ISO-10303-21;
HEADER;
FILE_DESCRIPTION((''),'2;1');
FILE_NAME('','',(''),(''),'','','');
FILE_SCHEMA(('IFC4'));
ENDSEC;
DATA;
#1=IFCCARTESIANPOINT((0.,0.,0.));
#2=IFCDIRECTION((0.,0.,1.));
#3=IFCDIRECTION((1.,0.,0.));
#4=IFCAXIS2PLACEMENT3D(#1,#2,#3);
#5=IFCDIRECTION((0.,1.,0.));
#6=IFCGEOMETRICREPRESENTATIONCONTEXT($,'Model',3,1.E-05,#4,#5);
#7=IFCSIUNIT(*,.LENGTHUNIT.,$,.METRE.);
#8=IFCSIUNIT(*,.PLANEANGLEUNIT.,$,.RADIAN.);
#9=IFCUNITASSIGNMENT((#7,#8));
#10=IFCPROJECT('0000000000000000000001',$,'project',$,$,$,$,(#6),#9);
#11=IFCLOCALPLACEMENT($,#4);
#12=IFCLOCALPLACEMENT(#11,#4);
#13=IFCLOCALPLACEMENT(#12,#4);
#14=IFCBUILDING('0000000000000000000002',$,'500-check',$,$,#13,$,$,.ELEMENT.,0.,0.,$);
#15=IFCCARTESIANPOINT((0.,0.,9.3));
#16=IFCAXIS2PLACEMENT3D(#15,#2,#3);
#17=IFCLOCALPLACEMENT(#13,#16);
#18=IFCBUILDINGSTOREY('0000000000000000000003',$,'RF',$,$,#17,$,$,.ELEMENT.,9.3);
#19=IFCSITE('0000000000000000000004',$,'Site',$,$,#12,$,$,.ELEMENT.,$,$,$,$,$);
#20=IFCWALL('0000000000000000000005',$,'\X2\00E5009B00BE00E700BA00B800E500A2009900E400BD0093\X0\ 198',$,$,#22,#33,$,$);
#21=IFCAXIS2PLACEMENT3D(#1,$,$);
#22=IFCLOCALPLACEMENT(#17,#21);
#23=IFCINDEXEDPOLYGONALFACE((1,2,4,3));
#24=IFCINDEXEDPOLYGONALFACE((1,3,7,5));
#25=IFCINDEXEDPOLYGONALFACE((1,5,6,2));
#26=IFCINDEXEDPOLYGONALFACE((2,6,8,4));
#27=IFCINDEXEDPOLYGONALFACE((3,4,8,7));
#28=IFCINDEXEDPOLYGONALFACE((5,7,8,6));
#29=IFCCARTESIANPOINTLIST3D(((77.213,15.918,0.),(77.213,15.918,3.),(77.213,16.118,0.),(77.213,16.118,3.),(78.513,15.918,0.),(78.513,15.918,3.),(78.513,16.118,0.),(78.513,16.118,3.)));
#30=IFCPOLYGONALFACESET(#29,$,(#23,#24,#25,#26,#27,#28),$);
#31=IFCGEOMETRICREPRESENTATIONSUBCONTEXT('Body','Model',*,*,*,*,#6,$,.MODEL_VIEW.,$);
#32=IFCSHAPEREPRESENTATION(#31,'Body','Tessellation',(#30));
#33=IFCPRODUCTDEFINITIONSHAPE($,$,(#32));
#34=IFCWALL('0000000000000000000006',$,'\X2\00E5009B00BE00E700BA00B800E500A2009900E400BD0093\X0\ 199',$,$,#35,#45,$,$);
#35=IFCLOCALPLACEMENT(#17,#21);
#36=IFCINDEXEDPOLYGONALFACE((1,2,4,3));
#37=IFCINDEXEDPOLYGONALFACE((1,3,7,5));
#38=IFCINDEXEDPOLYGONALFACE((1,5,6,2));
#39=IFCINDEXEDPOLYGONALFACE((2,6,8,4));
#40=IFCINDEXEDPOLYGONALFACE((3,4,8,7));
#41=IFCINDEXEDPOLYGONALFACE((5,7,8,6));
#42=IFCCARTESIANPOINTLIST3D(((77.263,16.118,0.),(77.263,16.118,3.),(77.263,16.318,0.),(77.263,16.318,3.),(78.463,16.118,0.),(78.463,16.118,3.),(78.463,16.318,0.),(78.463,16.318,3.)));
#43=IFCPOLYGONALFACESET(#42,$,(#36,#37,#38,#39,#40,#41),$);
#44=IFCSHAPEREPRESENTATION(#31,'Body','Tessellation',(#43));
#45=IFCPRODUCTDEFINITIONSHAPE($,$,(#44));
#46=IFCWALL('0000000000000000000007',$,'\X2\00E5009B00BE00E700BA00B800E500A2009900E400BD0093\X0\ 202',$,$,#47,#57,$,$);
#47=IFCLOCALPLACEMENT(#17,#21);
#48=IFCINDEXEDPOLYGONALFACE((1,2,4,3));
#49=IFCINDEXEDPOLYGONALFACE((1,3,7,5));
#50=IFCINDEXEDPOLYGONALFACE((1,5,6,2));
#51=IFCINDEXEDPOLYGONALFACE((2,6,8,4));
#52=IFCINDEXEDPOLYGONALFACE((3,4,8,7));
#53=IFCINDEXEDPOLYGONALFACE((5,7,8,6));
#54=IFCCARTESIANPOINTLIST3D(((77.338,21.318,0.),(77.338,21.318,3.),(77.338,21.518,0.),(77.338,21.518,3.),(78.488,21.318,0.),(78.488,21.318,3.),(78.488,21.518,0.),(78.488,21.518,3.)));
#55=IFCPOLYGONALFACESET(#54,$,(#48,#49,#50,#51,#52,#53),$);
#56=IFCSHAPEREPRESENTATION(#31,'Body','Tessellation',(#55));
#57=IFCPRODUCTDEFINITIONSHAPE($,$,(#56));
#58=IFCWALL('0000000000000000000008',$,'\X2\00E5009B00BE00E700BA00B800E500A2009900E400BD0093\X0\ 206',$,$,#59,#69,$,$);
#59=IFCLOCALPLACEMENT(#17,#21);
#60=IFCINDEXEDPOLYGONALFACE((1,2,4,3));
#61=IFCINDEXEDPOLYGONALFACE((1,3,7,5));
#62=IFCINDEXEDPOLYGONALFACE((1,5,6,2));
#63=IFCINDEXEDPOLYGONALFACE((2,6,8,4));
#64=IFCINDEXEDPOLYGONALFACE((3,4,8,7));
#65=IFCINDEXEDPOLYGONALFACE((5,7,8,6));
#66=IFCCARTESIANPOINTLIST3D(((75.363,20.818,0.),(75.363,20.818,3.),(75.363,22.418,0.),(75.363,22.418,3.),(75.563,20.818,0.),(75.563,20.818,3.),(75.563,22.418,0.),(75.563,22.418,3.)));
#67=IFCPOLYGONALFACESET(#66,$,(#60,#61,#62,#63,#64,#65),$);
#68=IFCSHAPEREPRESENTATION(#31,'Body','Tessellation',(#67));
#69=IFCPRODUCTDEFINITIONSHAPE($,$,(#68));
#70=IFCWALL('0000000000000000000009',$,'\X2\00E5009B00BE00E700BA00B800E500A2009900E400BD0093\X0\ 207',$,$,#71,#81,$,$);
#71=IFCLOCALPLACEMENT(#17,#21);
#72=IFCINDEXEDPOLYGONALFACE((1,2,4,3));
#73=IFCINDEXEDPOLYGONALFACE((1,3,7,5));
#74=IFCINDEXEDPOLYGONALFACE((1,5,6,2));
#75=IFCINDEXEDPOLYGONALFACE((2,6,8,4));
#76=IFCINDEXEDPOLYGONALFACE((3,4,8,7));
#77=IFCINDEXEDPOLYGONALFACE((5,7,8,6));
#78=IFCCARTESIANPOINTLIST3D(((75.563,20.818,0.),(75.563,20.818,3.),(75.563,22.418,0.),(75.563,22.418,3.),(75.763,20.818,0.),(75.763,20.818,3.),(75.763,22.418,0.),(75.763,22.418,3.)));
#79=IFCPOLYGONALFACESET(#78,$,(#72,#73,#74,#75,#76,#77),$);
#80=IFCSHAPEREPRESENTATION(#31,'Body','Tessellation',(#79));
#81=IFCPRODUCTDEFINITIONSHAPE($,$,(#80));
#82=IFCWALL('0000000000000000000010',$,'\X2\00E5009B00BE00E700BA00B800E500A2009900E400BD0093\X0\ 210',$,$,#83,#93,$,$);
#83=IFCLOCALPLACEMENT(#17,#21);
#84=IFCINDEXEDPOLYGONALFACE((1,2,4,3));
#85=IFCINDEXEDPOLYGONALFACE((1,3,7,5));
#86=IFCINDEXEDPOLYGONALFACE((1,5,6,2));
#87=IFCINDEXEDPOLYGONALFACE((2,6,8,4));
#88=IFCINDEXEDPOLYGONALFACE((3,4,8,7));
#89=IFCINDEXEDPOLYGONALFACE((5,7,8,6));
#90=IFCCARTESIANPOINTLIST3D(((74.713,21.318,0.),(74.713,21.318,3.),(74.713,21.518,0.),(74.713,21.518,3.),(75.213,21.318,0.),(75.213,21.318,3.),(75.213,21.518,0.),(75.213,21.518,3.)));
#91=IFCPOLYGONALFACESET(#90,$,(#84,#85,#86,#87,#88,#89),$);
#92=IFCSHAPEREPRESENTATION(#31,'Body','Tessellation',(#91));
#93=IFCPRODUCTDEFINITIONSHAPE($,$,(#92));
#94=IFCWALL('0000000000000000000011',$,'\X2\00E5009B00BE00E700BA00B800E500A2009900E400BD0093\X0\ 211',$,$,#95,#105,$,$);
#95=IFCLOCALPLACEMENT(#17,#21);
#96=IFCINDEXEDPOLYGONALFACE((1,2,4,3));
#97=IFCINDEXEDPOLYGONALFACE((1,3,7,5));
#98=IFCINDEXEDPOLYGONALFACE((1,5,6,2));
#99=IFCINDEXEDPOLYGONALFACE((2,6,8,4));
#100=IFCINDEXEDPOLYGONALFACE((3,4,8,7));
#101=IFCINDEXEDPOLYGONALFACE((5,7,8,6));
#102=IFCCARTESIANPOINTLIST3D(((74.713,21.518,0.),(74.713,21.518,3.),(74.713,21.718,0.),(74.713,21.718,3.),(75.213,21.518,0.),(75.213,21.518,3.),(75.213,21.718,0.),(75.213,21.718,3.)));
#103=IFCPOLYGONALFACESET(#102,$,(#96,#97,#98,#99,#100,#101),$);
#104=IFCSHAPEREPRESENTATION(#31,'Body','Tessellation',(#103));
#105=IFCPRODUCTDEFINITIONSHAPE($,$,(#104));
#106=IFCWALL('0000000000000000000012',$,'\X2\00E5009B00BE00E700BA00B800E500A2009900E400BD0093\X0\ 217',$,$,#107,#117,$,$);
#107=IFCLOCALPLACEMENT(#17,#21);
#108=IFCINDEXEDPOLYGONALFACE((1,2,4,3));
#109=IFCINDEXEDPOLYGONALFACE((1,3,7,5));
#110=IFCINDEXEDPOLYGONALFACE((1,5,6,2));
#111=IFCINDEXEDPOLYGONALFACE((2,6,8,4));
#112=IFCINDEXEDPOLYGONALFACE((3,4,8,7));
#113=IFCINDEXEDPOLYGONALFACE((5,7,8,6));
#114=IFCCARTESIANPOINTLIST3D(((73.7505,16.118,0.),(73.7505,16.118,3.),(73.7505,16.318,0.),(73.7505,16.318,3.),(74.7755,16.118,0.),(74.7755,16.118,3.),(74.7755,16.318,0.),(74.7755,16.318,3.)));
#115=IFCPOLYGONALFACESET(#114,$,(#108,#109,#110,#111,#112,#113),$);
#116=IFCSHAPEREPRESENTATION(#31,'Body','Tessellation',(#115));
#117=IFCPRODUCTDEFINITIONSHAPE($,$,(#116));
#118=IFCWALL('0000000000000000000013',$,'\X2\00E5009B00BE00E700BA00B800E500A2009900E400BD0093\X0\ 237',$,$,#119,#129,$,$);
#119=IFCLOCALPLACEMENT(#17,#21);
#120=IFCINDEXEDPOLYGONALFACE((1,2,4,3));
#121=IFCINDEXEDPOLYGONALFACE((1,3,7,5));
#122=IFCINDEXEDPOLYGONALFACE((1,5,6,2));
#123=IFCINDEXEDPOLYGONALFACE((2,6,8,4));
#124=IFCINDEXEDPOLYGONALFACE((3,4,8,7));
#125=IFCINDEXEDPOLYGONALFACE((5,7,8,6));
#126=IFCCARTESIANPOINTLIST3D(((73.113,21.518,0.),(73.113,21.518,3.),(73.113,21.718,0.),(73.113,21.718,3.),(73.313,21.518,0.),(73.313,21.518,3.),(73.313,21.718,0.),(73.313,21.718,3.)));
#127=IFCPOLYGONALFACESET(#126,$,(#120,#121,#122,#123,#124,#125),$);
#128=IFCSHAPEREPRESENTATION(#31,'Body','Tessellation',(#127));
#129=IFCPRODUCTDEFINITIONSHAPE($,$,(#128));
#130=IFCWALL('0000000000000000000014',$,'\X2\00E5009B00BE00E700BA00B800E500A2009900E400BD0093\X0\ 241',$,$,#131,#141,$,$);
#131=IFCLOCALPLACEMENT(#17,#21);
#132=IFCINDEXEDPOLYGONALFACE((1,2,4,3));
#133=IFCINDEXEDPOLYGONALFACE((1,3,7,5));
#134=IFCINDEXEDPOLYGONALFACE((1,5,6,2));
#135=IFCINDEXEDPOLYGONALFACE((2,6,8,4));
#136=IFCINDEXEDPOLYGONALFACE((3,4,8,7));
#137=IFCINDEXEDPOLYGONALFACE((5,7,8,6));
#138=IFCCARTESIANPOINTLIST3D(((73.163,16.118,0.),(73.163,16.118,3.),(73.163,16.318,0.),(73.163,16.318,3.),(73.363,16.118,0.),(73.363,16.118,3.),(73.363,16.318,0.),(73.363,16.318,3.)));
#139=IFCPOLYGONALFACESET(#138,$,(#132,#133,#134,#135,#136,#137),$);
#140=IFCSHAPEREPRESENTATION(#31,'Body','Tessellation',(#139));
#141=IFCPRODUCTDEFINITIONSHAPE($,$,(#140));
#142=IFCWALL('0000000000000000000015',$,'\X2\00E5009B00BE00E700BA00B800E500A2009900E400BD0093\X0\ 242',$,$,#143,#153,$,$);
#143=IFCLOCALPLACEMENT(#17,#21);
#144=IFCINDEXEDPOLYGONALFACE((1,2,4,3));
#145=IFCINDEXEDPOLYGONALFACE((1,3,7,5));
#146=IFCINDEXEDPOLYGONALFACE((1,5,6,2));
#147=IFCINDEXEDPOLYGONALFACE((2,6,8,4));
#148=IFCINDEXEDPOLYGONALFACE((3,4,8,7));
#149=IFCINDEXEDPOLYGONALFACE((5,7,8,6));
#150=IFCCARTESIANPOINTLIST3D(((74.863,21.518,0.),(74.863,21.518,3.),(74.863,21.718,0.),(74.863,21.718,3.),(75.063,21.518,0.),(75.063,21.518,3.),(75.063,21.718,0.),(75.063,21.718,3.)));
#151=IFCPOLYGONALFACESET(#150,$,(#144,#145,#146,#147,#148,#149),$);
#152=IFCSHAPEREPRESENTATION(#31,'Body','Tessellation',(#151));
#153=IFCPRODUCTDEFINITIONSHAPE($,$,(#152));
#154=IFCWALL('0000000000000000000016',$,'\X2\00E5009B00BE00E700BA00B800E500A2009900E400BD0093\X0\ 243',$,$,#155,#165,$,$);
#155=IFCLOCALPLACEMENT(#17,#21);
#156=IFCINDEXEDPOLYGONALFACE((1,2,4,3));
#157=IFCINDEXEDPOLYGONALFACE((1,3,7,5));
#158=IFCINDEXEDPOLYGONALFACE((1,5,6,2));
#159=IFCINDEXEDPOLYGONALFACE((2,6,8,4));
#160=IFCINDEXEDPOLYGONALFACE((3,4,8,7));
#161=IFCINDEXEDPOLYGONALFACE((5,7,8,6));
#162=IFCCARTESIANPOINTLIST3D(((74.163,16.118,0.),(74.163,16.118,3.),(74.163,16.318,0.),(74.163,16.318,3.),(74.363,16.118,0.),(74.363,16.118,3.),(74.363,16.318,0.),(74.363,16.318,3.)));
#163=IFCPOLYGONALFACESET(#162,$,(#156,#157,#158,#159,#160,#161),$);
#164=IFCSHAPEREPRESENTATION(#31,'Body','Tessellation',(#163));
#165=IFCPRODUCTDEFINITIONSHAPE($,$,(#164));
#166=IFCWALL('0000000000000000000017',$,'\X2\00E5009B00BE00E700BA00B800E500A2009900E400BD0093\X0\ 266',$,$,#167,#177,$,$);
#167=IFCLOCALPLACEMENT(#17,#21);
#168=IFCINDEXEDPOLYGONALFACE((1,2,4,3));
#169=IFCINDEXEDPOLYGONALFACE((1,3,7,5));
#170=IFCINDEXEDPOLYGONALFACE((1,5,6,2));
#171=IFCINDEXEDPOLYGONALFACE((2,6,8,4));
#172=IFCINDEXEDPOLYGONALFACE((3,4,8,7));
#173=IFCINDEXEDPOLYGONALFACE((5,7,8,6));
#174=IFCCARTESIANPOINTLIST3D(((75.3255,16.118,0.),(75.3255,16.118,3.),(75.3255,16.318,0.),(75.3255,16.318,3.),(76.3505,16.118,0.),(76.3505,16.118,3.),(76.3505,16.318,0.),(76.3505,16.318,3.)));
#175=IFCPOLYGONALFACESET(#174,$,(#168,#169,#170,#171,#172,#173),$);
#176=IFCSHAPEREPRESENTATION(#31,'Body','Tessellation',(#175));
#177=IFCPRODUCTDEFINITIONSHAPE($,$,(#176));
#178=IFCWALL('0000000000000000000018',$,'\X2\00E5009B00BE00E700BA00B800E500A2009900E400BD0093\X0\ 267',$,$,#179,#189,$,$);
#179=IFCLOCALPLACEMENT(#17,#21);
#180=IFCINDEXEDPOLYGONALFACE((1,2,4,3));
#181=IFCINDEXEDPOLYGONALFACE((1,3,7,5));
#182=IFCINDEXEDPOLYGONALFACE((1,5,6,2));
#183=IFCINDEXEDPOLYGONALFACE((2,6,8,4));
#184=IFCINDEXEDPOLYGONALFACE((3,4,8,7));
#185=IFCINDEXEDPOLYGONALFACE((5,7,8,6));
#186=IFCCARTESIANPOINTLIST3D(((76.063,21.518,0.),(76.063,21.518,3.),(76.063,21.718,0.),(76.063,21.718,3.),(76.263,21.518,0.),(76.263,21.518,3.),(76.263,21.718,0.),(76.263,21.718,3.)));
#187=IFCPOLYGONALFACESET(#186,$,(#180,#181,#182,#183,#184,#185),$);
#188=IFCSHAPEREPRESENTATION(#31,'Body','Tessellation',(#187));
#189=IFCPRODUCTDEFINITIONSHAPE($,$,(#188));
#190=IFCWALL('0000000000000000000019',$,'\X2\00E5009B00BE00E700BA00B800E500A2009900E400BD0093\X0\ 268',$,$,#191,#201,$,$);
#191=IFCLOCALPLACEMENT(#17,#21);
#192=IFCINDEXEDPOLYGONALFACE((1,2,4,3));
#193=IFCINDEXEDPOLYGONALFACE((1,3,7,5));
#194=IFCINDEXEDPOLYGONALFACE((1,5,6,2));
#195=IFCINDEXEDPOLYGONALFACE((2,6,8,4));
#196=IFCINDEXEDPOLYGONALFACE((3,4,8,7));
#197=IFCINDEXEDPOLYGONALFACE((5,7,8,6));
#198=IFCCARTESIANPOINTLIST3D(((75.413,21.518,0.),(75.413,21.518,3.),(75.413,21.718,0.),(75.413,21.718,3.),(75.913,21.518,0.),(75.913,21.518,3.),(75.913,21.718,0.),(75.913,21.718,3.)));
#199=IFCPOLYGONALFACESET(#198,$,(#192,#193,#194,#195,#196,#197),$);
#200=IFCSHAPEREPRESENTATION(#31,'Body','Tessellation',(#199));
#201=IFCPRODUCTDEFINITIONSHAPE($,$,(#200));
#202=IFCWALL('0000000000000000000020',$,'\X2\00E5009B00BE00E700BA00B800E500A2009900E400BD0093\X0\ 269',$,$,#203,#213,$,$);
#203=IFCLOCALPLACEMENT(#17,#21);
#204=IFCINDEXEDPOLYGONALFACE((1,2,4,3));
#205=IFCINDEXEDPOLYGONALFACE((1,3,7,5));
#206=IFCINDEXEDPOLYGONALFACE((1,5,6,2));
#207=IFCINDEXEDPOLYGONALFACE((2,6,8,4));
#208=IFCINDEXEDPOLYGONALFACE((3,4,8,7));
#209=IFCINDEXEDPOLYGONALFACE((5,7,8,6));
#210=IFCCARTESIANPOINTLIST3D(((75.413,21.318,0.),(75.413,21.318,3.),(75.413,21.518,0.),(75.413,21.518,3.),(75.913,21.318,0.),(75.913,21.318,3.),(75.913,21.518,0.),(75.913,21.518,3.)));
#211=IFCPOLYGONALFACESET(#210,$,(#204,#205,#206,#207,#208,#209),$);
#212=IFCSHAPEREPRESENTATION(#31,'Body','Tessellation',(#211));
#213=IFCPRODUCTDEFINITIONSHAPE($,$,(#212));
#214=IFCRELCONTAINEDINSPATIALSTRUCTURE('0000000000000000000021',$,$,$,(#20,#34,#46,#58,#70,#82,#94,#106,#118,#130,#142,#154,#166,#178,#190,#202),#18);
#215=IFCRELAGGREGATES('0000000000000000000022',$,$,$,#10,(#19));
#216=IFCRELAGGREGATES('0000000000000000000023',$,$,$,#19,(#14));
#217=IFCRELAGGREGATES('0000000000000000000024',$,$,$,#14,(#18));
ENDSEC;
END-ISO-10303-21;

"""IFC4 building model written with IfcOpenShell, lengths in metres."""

from ifc_helpers import new_model, si_unit, direction, frame, frame_2d, origin_with_axes, place, context, subcontext, project, spatial, rectangle, extrude, element, save


model = new_model("IFC4")

# Units and contexts
model_context = context("Model", 3, precision=1e-05, world=origin_with_axes(), true_north=direction((0.0, 1.0, 0.0)))
body_context = subcontext(model_context, "Body", "Model", "MODEL_VIEW")
ifc_project = project(units=[si_unit("LENGTHUNIT", "METRE"), si_unit("PLANEANGLEUNIT", "RADIAN")], contexts=[model_context])

# Site, building, storey
placement = place(None, origin_with_axes())
site_placement = place(placement, origin_with_axes())
site = spatial("IfcSite", under=ifc_project, at=site_placement, Name="Site", CompositionType="ELEMENT")
building_placement = place(site_placement, origin_with_axes())
building = spatial("IfcBuilding", under=site, at=building_placement, Name="500-check", CompositionType="ELEMENT", ElevationOfRefHeight=0.0, ElevationOfTerrain=0.0)
storey_placement = place(building_placement, frame((0.0, 0.0, 9.3), z_axis=(0.0, 0.0, 1.0), x_axis=(1.0, 0.0, 0.0)))
storey = spatial("IfcBuildingStorey", under=building, at=storey_placement, Name="RF", CompositionType="ELEMENT", Elevation=9.3)

# Walls
wall_1_placement = place(storey_placement, frame((77.863, 16.018, 0.0), z_axis=(0.0, 0.0, 1.0), x_axis=(1.0, 0.0, 0.0)))
element("IfcWall", 1, at=wall_1_placement, inside=storey, Name="å\u009b¾çº¸å¢\u0099ä½\u0093 198", context=body_context, shape_type="SweptSolid", body=[
    extrude(rectangle(XDim=1.3, YDim=0.2, at=frame_2d((0.0, 0.0), x_axis=(1.0, 0.0, 0.0))), frame((0.0, 0.0, 0.0), z_axis=(0.0, 0.0, 1.0)), (0.0, 0.0, 1.0), 3.0),
])
wall_2_placement = place(storey_placement, frame((77.863, 16.218, 0.0), z_axis=(0.0, 0.0, 1.0), x_axis=(1.0, 0.0, 0.0)))
element("IfcWall", 2, at=wall_2_placement, inside=storey, Name="å\u009b¾çº¸å¢\u0099ä½\u0093 199", context=body_context, shape_type="SweptSolid", body=[
    extrude(rectangle(XDim=1.2, YDim=0.2, at=frame_2d((0.0, 0.0), x_axis=(1.0, 0.0, 0.0))), frame((0.0, 0.0, 0.0), z_axis=(0.0, 0.0, 1.0)), (0.0, 0.0, 1.0), 3.0),
])
wall_3_placement = place(storey_placement, frame((77.913, 21.418, 0.0), z_axis=(0.0, 0.0, 1.0), x_axis=(1.0, 0.0, 0.0)))
element("IfcWall", 3, at=wall_3_placement, inside=storey, Name="å\u009b¾çº¸å¢\u0099ä½\u0093 202", context=body_context, shape_type="SweptSolid", body=[
    extrude(rectangle(XDim=1.15, YDim=0.2, at=frame_2d((0.0, 0.0), x_axis=(1.0, 0.0, 0.0))), frame((0.0, 0.0, 0.0), z_axis=(0.0, 0.0, 1.0)), (0.0, 0.0, 1.0), 3.0),
])
for number, where, z_axis, x_axis, name in (
    (4, (75.463, 21.618, 0.0), (0.0, 0.0, 1.0), (0.0, 1.0, 0.0), "å\u009b¾çº¸å¢\u0099ä½\u0093 206"),
    (5, (75.663, 21.618, 0.0), (0.0, 0.0, 1.0), (0.0, 1.0, 0.0), "å\u009b¾çº¸å¢\u0099ä½\u0093 207"),
):
    element("IfcWall", number, at=place(storey_placement, frame(where, z_axis=z_axis, x_axis=x_axis)), inside=storey, Name=name, context=body_context, shape_type="SweptSolid", body=[
        extrude(rectangle(XDim=1.6, YDim=0.2, at=frame_2d((0.0, 0.0), x_axis=(1.0, 0.0, 0.0))), frame((0.0, 0.0, 0.0), z_axis=(0.0, 0.0, 1.0)), (0.0, 0.0, 1.0), 3.0),
    ])
for number, where, z_axis, x_axis, name in (
    (6, (74.963, 21.418, 0.0), (0.0, 0.0, 1.0), (1.0, 0.0, 0.0), "å\u009b¾çº¸å¢\u0099ä½\u0093 210"),
    (7, (74.963, 21.618, 0.0), (0.0, 0.0, 1.0), (1.0, 0.0, 0.0), "å\u009b¾çº¸å¢\u0099ä½\u0093 211"),
):
    element("IfcWall", number, at=place(storey_placement, frame(where, z_axis=z_axis, x_axis=x_axis)), inside=storey, Name=name, context=body_context, shape_type="SweptSolid", body=[
        extrude(rectangle(XDim=0.5, YDim=0.2, at=frame_2d((0.0, 0.0), x_axis=(1.0, 0.0, 0.0))), frame((0.0, 0.0, 0.0), z_axis=(0.0, 0.0, 1.0)), (0.0, 0.0, 1.0), 3.0),
    ])
wall_4_placement = place(storey_placement, frame((74.263, 16.218, 0.0), z_axis=(0.0, 0.0, 1.0), x_axis=(1.0, 0.0, 0.0)))
element("IfcWall", 8, at=wall_4_placement, inside=storey, Name="å\u009b¾çº¸å¢\u0099ä½\u0093 217", context=body_context, shape_type="SweptSolid", body=[
    extrude(rectangle(XDim=1.025, YDim=0.2, at=frame_2d((0.0, 0.0), x_axis=(1.0, 0.0, 0.0))), frame((0.0, 0.0, 0.0), z_axis=(0.0, 0.0, 1.0)), (0.0, 0.0, 1.0), 3.0),
])
for number, where, z_axis, x_axis, name in (
    (9, (73.213, 21.618, 0.0), (0.0, 0.0, 1.0), (0.0, -1.0, 0.0), "å\u009b¾çº¸å¢\u0099ä½\u0093 237"),
    (10, (73.263, 16.218, 0.0), (0.0, 0.0, 1.0), (0.0, -1.0, 0.0), "å\u009b¾çº¸å¢\u0099ä½\u0093 241"),
    (11, (74.963, 21.618, 0.0), (0.0, 0.0, 1.0), (0.0, -1.0, 0.0), "å\u009b¾çº¸å¢\u0099ä½\u0093 242"),
    (12, (74.263, 16.218, 0.0), (0.0, 0.0, 1.0), (0.0, -1.0, 0.0), "å\u009b¾çº¸å¢\u0099ä½\u0093 243"),
):
    element("IfcWall", number, at=place(storey_placement, frame(where, z_axis=z_axis, x_axis=x_axis)), inside=storey, Name=name, context=body_context, shape_type="SweptSolid", body=[
        extrude(rectangle(XDim=0.2, YDim=0.2, at=frame_2d((0.0, 0.0), x_axis=(1.0, 0.0, 0.0))), frame((0.0, 0.0, 0.0), z_axis=(0.0, 0.0, 1.0)), (0.0, 0.0, 1.0), 3.0),
    ])
wall_5_placement = place(storey_placement, frame((75.838, 16.218, 0.0), z_axis=(0.0, 0.0, 1.0), x_axis=(1.0, 0.0, 0.0)))
element("IfcWall", 13, at=wall_5_placement, inside=storey, Name="å\u009b¾çº¸å¢\u0099ä½\u0093 266", context=body_context, shape_type="SweptSolid", body=[
    extrude(rectangle(XDim=1.025, YDim=0.2, at=frame_2d((0.0, 0.0), x_axis=(1.0, 0.0, 0.0))), frame((0.0, 0.0, 0.0), z_axis=(0.0, 0.0, 1.0)), (0.0, 0.0, 1.0), 3.0),
])
wall_6_placement = place(storey_placement, frame((76.163, 21.618, 0.0), z_axis=(0.0, 0.0, 1.0), x_axis=(0.0, -1.0, 0.0)))
element("IfcWall", 14, at=wall_6_placement, inside=storey, Name="å\u009b¾çº¸å¢\u0099ä½\u0093 267", context=body_context, shape_type="SweptSolid", body=[
    extrude(rectangle(XDim=0.2, YDim=0.2, at=frame_2d((0.0, 0.0), x_axis=(1.0, 0.0, 0.0))), frame((0.0, 0.0, 0.0), z_axis=(0.0, 0.0, 1.0)), (0.0, 0.0, 1.0), 3.0),
])
for number, where, z_axis, x_axis, name in (
    (15, (75.663, 21.618, 0.0), (0.0, 0.0, 1.0), (1.0, 0.0, 0.0), "å\u009b¾çº¸å¢\u0099ä½\u0093 268"),
    (16, (75.663, 21.418, 0.0), (0.0, 0.0, 1.0), (1.0, 0.0, 0.0), "å\u009b¾çº¸å¢\u0099ä½\u0093 269"),
):
    element("IfcWall", number, at=place(storey_placement, frame(where, z_axis=z_axis, x_axis=x_axis)), inside=storey, Name=name, context=body_context, shape_type="SweptSolid", body=[
        extrude(rectangle(XDim=0.5, YDim=0.2, at=frame_2d((0.0, 0.0), x_axis=(1.0, 0.0, 0.0))), frame((0.0, 0.0, 0.0), z_axis=(0.0, 0.0, 1.0)), (0.0, 0.0, 1.0), 3.0),
    ])

save(model, "model.ifc")
